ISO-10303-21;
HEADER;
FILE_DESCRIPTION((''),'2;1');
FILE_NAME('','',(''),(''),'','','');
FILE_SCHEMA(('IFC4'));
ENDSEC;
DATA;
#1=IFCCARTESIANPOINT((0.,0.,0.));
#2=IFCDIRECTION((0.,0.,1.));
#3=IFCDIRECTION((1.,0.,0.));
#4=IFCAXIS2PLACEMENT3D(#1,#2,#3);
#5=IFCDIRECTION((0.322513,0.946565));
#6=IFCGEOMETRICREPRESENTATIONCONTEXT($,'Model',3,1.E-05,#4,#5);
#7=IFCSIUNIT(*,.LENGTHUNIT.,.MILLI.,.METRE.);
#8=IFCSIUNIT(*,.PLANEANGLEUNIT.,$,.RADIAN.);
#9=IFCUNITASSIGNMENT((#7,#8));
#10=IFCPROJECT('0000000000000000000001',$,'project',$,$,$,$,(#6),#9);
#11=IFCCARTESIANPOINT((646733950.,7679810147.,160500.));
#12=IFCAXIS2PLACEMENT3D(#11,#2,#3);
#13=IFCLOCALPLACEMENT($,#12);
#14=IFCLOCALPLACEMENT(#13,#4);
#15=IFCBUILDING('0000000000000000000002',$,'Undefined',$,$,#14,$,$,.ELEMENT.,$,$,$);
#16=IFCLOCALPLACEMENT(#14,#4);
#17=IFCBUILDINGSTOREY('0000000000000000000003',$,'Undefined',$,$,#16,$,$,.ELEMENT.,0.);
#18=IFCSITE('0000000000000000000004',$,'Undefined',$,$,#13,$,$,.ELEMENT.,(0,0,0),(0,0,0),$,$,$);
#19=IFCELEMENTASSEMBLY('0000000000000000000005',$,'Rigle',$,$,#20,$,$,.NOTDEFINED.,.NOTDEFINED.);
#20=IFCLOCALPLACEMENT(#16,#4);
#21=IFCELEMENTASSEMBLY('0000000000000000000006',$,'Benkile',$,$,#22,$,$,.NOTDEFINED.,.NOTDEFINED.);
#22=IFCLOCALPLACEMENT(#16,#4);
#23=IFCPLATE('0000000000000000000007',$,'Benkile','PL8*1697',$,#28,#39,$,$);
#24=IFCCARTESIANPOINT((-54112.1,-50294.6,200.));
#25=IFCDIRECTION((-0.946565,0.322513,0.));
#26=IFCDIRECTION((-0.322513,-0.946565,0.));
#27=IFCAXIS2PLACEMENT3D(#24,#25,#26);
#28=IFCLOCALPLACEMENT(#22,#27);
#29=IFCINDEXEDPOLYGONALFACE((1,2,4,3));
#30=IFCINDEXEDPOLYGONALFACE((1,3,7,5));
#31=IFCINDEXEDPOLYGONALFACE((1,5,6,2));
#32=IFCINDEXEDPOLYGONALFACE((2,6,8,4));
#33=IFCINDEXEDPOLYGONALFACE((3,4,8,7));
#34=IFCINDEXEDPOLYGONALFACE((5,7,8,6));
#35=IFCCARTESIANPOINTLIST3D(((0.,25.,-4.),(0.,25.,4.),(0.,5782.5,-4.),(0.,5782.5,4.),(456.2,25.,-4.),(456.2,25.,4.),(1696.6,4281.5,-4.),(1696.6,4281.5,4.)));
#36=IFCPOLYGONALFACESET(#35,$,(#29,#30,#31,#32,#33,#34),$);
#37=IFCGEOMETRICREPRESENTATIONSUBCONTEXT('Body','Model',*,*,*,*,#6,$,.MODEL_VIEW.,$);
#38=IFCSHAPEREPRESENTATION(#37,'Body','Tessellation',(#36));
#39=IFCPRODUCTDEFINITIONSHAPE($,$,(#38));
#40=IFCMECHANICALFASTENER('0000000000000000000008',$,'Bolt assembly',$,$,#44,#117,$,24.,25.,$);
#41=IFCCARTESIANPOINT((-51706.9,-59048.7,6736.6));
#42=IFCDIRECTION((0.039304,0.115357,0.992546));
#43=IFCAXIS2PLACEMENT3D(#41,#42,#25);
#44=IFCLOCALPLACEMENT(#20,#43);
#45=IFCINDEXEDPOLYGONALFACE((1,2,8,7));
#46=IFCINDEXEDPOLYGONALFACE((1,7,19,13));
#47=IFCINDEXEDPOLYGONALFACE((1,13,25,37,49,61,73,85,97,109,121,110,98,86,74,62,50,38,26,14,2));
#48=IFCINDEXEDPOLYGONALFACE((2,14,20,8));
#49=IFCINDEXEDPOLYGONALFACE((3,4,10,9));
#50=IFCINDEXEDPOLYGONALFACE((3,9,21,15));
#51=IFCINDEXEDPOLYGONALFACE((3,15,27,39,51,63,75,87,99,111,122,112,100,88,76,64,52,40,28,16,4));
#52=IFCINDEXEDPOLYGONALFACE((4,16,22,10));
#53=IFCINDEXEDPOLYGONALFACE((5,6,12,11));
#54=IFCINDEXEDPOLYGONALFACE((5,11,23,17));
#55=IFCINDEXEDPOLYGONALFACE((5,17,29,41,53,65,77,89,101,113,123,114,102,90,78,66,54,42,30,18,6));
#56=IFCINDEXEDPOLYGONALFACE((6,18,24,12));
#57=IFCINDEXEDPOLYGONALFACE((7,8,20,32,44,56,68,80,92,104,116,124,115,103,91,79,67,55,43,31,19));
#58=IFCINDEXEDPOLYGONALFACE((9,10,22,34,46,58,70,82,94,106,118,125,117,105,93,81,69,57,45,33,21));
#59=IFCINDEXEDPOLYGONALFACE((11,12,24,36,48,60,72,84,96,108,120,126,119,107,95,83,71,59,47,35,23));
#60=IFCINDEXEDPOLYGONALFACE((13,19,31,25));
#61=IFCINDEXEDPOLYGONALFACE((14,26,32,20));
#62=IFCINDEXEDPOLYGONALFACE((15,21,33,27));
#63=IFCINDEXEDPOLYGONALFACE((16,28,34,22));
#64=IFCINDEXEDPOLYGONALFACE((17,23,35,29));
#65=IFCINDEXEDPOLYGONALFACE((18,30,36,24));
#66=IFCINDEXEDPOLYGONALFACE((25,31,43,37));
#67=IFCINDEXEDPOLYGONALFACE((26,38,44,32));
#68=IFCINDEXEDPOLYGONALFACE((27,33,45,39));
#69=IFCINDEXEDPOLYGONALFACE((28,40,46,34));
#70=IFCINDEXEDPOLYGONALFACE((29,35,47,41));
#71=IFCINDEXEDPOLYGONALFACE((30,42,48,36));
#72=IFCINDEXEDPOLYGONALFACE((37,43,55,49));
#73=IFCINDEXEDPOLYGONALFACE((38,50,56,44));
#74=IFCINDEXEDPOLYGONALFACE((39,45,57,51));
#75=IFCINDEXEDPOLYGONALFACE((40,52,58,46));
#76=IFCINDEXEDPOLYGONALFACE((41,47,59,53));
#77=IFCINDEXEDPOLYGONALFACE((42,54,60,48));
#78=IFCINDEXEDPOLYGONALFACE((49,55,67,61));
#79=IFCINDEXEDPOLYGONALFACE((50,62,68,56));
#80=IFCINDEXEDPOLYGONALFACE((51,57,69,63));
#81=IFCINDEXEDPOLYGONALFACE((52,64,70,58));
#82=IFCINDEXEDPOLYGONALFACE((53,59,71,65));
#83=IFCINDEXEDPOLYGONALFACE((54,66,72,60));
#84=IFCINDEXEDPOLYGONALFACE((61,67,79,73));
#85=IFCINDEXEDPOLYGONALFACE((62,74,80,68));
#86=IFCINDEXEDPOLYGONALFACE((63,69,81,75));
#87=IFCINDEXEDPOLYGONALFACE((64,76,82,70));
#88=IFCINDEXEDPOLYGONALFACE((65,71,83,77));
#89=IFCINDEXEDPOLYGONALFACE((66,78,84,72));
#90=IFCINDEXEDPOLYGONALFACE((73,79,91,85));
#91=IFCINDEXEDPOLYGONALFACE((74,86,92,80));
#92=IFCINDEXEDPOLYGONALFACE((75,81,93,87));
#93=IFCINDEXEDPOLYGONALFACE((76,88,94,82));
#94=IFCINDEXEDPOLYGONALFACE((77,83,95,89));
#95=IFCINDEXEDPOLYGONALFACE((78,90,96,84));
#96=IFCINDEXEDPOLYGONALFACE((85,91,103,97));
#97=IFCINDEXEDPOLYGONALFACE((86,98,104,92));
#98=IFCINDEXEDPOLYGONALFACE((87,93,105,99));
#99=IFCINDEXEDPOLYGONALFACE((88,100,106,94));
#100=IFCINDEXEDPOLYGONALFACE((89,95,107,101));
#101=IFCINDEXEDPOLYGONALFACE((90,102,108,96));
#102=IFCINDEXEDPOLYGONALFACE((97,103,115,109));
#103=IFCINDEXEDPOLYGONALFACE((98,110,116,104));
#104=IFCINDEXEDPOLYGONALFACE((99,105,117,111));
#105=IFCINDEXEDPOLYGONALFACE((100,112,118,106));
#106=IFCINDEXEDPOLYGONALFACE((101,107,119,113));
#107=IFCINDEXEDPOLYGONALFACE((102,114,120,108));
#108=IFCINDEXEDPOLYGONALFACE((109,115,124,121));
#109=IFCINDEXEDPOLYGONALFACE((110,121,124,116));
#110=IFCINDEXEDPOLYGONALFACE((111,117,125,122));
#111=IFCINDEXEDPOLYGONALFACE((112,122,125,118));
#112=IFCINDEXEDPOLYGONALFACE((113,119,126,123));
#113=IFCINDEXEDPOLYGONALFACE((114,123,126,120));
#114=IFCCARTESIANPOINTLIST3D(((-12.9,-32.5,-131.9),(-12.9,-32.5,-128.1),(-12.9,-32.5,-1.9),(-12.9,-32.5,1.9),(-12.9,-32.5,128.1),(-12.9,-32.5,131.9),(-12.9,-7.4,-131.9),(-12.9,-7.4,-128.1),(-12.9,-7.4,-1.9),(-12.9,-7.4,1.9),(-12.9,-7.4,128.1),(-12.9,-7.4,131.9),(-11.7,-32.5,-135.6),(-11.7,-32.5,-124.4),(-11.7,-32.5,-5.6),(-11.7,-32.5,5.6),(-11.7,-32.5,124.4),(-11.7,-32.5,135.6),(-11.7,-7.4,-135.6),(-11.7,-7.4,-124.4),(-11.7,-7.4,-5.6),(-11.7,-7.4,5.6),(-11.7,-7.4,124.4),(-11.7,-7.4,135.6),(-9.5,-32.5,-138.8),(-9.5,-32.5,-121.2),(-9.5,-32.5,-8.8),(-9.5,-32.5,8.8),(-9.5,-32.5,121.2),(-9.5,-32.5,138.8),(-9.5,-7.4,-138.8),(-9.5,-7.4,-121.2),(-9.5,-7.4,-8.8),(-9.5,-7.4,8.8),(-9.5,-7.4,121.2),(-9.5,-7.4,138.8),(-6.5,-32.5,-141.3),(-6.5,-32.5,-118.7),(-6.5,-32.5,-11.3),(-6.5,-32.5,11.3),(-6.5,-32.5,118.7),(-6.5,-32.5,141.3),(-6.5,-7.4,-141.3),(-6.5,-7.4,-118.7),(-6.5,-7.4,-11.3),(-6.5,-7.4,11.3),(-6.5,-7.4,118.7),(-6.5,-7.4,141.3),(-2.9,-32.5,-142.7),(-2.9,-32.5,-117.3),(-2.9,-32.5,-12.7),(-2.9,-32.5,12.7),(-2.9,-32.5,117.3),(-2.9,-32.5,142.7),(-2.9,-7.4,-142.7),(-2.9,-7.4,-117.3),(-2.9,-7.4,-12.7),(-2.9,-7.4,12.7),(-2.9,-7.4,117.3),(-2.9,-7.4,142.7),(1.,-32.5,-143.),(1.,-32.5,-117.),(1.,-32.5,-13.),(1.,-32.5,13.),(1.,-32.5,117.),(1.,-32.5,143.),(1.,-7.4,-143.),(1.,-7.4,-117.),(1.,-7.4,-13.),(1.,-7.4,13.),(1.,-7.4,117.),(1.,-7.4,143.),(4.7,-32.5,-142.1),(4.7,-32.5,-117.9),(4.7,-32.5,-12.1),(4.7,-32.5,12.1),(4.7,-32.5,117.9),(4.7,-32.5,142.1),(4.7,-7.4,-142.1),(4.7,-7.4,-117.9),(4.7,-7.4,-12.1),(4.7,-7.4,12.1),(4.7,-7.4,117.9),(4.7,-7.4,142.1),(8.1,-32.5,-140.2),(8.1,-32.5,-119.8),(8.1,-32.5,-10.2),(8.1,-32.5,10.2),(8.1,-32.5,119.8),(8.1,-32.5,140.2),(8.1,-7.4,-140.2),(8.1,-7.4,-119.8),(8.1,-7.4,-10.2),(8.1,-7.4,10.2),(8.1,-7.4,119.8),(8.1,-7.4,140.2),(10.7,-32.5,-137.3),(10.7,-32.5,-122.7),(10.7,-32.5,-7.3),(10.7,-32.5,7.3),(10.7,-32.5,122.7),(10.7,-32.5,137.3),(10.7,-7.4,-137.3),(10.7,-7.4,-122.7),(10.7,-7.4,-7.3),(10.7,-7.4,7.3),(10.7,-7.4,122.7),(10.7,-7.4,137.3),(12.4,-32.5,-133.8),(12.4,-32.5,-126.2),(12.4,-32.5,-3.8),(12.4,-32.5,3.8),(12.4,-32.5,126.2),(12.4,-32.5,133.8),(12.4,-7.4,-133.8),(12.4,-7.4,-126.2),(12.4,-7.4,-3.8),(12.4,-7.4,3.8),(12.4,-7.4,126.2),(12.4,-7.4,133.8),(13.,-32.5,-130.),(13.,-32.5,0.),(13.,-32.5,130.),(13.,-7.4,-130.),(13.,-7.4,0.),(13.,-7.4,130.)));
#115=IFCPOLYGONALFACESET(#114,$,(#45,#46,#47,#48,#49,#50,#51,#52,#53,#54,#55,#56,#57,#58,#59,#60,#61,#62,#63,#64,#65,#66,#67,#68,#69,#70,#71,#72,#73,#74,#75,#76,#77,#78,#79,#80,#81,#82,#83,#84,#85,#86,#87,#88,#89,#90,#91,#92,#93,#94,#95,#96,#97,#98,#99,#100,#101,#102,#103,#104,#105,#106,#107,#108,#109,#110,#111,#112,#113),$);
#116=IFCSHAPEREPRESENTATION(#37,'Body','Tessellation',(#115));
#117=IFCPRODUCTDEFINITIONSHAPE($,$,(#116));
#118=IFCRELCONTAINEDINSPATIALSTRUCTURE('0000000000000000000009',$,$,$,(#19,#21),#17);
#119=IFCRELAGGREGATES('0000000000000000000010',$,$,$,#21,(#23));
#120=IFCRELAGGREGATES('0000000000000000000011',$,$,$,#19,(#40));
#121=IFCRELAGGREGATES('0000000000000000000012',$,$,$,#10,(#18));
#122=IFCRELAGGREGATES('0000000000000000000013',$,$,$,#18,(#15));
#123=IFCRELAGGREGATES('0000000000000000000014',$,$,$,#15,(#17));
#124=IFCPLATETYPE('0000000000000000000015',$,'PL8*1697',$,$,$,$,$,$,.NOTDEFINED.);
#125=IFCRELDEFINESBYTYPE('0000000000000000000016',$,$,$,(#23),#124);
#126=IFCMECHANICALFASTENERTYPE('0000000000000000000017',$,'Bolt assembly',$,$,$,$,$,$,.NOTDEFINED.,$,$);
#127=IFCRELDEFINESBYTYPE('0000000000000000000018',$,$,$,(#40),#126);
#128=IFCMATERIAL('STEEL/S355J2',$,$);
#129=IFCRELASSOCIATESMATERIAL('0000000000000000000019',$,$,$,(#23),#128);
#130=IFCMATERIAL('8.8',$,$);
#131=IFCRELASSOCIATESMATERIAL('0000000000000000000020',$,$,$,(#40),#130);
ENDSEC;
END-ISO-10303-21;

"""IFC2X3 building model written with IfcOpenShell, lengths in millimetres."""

from ifc_helpers import new_model, si_unit, direction, frame, origin_with_axes, origin_2d_with_axis, place, context, subcontext, project, spatial, polyline, circle, outline, extrude, clip, halfspace, source, transform, mapped, material, type_object, element, aggregate, save


model = new_model("IFC2X3")

# Units and contexts
model_context = context("Model", 3, precision=1e-05, world=origin_with_axes(), true_north=direction((0.322513, 0.946565)))
body_context = subcontext(model_context, "Body", "Model", "MODEL_VIEW")
ifc_project = project(units=[si_unit("LENGTHUNIT", "METRE", prefix="MILLI"), si_unit("PLANEANGLEUNIT", "RADIAN")], contexts=[model_context])

# Site, building, storey
site_placement = place(None, frame((646733950.0, 7679810147.0, 160500.0), z_axis=(0.0, 0.0, 1.0), x_axis=(1.0, 0.0, 0.0)))
site = spatial("IfcSite", under=ifc_project, at=site_placement, Name="Undefined", CompositionType="ELEMENT", RefLatitude=(0, 0, 0), RefLongitude=(0, 0, 0))
building_placement = place(site_placement, origin_with_axes())
building = spatial("IfcBuilding", under=site, at=building_placement, Name="Undefined", CompositionType="ELEMENT")
storey_placement = place(building_placement, origin_with_axes())
storey = spatial("IfcBuildingStorey", under=building, at=storey_placement, Name="Undefined", CompositionType="ELEMENT", Elevation=0.0)

# Element assemblies
assembly_1_placement = place(storey_placement, origin_with_axes())
assembly_1 = element("IfcElementAssembly", 1, at=assembly_1_placement, inside=storey, Name="Rigle", AssemblyPlace="NOTDEFINED", PredefinedType="NOTDEFINED")
ifc_material_1 = material(Name="STEEL/S355J2")
assembly_2_placement = place(storey_placement, origin_with_axes())
assembly_2 = element("IfcElementAssembly", 2, at=assembly_2_placement, inside=storey, Name="Benkile", AssemblyPlace="NOTDEFINED", PredefinedType="NOTDEFINED")

# Plate
plate_type_1 = type_object("IfcPlateType", Name="PL8*1697", PredefinedType="NOTDEFINED")
plate_1_placement = place(assembly_2_placement, frame((-54112.1, -50294.6, 200.0), z_axis=(-0.946565, 0.322513, 0.0), x_axis=(-0.322513, -0.946565, 0.0)))
plate_1 = element("IfcPlate", 3, at=plate_1_placement, type_object=plate_type_1, material=ifc_material_1, Name="Benkile", Description="PL8*1697", context=body_context, shape_type="Clipping", body=[
    clip(extrude(outline(polyline([(0.0, 0.0), (449.0, 0.0), (1696.6, 4281.5), (0.0, 5782.5), (0.0, 0.0)])), frame((0.0, 0.0, -4.0), z_axis=(0.0, 0.0, 1.0), x_axis=(1.0, 0.0, 0.0)), (0.0, 0.0, 1.0), 8.0), halfspace(frame((0.0, 25.0, -4.0), z_axis=(0.0, -1.0, 0.0), x_axis=(0.0, 0.0, 1.0)), False)),
])

# Mechanical fastener
ifc_material_2 = material(Name="8.8")
mechanical_fastener_type = type_object("IfcMechanicalFastenerType", Name="Bolt assembly")
aggregate(assembly_2, [plate_1])
shared_shape_1 = source(origin_with_axes(), body_context, "Body", "SweptSolid", [
    extrude(circle(Radius=13.0, at=origin_2d_with_axis()), frame((0.0, -32.5, 0.0), z_axis=(0.0, 1.0, 0.0), x_axis=(1.0, 0.0, 0.0)), (0.0, 0.0, 1.0), 25.1),
])
mechanical_fastener_1_placement = place(assembly_1_placement, frame((-51706.9, -59048.7, 6736.6), z_axis=(0.039304, 0.115357, 0.992546), x_axis=(-0.946565, 0.322513, 0.0)))
mechanical_fastener_1 = element("IfcMechanicalFastener", 4, at=mechanical_fastener_1_placement, type_object=mechanical_fastener_type, material=ifc_material_2, Name="Bolt assembly", NominalDiameter=24.0, NominalLength=25.0, context=body_context, shape_type="MappedRepresentation", body=[
    mapped(shared_shape_1, transform((0.0, 0.0, -130.0))),
    mapped(shared_shape_1, transform((0.0, 0.0, 0.0))),
    mapped(shared_shape_1, transform((0.0, 0.0, 130.0))),
])
aggregate(assembly_1, [mechanical_fastener_1])

save(model, "model.ifc")
